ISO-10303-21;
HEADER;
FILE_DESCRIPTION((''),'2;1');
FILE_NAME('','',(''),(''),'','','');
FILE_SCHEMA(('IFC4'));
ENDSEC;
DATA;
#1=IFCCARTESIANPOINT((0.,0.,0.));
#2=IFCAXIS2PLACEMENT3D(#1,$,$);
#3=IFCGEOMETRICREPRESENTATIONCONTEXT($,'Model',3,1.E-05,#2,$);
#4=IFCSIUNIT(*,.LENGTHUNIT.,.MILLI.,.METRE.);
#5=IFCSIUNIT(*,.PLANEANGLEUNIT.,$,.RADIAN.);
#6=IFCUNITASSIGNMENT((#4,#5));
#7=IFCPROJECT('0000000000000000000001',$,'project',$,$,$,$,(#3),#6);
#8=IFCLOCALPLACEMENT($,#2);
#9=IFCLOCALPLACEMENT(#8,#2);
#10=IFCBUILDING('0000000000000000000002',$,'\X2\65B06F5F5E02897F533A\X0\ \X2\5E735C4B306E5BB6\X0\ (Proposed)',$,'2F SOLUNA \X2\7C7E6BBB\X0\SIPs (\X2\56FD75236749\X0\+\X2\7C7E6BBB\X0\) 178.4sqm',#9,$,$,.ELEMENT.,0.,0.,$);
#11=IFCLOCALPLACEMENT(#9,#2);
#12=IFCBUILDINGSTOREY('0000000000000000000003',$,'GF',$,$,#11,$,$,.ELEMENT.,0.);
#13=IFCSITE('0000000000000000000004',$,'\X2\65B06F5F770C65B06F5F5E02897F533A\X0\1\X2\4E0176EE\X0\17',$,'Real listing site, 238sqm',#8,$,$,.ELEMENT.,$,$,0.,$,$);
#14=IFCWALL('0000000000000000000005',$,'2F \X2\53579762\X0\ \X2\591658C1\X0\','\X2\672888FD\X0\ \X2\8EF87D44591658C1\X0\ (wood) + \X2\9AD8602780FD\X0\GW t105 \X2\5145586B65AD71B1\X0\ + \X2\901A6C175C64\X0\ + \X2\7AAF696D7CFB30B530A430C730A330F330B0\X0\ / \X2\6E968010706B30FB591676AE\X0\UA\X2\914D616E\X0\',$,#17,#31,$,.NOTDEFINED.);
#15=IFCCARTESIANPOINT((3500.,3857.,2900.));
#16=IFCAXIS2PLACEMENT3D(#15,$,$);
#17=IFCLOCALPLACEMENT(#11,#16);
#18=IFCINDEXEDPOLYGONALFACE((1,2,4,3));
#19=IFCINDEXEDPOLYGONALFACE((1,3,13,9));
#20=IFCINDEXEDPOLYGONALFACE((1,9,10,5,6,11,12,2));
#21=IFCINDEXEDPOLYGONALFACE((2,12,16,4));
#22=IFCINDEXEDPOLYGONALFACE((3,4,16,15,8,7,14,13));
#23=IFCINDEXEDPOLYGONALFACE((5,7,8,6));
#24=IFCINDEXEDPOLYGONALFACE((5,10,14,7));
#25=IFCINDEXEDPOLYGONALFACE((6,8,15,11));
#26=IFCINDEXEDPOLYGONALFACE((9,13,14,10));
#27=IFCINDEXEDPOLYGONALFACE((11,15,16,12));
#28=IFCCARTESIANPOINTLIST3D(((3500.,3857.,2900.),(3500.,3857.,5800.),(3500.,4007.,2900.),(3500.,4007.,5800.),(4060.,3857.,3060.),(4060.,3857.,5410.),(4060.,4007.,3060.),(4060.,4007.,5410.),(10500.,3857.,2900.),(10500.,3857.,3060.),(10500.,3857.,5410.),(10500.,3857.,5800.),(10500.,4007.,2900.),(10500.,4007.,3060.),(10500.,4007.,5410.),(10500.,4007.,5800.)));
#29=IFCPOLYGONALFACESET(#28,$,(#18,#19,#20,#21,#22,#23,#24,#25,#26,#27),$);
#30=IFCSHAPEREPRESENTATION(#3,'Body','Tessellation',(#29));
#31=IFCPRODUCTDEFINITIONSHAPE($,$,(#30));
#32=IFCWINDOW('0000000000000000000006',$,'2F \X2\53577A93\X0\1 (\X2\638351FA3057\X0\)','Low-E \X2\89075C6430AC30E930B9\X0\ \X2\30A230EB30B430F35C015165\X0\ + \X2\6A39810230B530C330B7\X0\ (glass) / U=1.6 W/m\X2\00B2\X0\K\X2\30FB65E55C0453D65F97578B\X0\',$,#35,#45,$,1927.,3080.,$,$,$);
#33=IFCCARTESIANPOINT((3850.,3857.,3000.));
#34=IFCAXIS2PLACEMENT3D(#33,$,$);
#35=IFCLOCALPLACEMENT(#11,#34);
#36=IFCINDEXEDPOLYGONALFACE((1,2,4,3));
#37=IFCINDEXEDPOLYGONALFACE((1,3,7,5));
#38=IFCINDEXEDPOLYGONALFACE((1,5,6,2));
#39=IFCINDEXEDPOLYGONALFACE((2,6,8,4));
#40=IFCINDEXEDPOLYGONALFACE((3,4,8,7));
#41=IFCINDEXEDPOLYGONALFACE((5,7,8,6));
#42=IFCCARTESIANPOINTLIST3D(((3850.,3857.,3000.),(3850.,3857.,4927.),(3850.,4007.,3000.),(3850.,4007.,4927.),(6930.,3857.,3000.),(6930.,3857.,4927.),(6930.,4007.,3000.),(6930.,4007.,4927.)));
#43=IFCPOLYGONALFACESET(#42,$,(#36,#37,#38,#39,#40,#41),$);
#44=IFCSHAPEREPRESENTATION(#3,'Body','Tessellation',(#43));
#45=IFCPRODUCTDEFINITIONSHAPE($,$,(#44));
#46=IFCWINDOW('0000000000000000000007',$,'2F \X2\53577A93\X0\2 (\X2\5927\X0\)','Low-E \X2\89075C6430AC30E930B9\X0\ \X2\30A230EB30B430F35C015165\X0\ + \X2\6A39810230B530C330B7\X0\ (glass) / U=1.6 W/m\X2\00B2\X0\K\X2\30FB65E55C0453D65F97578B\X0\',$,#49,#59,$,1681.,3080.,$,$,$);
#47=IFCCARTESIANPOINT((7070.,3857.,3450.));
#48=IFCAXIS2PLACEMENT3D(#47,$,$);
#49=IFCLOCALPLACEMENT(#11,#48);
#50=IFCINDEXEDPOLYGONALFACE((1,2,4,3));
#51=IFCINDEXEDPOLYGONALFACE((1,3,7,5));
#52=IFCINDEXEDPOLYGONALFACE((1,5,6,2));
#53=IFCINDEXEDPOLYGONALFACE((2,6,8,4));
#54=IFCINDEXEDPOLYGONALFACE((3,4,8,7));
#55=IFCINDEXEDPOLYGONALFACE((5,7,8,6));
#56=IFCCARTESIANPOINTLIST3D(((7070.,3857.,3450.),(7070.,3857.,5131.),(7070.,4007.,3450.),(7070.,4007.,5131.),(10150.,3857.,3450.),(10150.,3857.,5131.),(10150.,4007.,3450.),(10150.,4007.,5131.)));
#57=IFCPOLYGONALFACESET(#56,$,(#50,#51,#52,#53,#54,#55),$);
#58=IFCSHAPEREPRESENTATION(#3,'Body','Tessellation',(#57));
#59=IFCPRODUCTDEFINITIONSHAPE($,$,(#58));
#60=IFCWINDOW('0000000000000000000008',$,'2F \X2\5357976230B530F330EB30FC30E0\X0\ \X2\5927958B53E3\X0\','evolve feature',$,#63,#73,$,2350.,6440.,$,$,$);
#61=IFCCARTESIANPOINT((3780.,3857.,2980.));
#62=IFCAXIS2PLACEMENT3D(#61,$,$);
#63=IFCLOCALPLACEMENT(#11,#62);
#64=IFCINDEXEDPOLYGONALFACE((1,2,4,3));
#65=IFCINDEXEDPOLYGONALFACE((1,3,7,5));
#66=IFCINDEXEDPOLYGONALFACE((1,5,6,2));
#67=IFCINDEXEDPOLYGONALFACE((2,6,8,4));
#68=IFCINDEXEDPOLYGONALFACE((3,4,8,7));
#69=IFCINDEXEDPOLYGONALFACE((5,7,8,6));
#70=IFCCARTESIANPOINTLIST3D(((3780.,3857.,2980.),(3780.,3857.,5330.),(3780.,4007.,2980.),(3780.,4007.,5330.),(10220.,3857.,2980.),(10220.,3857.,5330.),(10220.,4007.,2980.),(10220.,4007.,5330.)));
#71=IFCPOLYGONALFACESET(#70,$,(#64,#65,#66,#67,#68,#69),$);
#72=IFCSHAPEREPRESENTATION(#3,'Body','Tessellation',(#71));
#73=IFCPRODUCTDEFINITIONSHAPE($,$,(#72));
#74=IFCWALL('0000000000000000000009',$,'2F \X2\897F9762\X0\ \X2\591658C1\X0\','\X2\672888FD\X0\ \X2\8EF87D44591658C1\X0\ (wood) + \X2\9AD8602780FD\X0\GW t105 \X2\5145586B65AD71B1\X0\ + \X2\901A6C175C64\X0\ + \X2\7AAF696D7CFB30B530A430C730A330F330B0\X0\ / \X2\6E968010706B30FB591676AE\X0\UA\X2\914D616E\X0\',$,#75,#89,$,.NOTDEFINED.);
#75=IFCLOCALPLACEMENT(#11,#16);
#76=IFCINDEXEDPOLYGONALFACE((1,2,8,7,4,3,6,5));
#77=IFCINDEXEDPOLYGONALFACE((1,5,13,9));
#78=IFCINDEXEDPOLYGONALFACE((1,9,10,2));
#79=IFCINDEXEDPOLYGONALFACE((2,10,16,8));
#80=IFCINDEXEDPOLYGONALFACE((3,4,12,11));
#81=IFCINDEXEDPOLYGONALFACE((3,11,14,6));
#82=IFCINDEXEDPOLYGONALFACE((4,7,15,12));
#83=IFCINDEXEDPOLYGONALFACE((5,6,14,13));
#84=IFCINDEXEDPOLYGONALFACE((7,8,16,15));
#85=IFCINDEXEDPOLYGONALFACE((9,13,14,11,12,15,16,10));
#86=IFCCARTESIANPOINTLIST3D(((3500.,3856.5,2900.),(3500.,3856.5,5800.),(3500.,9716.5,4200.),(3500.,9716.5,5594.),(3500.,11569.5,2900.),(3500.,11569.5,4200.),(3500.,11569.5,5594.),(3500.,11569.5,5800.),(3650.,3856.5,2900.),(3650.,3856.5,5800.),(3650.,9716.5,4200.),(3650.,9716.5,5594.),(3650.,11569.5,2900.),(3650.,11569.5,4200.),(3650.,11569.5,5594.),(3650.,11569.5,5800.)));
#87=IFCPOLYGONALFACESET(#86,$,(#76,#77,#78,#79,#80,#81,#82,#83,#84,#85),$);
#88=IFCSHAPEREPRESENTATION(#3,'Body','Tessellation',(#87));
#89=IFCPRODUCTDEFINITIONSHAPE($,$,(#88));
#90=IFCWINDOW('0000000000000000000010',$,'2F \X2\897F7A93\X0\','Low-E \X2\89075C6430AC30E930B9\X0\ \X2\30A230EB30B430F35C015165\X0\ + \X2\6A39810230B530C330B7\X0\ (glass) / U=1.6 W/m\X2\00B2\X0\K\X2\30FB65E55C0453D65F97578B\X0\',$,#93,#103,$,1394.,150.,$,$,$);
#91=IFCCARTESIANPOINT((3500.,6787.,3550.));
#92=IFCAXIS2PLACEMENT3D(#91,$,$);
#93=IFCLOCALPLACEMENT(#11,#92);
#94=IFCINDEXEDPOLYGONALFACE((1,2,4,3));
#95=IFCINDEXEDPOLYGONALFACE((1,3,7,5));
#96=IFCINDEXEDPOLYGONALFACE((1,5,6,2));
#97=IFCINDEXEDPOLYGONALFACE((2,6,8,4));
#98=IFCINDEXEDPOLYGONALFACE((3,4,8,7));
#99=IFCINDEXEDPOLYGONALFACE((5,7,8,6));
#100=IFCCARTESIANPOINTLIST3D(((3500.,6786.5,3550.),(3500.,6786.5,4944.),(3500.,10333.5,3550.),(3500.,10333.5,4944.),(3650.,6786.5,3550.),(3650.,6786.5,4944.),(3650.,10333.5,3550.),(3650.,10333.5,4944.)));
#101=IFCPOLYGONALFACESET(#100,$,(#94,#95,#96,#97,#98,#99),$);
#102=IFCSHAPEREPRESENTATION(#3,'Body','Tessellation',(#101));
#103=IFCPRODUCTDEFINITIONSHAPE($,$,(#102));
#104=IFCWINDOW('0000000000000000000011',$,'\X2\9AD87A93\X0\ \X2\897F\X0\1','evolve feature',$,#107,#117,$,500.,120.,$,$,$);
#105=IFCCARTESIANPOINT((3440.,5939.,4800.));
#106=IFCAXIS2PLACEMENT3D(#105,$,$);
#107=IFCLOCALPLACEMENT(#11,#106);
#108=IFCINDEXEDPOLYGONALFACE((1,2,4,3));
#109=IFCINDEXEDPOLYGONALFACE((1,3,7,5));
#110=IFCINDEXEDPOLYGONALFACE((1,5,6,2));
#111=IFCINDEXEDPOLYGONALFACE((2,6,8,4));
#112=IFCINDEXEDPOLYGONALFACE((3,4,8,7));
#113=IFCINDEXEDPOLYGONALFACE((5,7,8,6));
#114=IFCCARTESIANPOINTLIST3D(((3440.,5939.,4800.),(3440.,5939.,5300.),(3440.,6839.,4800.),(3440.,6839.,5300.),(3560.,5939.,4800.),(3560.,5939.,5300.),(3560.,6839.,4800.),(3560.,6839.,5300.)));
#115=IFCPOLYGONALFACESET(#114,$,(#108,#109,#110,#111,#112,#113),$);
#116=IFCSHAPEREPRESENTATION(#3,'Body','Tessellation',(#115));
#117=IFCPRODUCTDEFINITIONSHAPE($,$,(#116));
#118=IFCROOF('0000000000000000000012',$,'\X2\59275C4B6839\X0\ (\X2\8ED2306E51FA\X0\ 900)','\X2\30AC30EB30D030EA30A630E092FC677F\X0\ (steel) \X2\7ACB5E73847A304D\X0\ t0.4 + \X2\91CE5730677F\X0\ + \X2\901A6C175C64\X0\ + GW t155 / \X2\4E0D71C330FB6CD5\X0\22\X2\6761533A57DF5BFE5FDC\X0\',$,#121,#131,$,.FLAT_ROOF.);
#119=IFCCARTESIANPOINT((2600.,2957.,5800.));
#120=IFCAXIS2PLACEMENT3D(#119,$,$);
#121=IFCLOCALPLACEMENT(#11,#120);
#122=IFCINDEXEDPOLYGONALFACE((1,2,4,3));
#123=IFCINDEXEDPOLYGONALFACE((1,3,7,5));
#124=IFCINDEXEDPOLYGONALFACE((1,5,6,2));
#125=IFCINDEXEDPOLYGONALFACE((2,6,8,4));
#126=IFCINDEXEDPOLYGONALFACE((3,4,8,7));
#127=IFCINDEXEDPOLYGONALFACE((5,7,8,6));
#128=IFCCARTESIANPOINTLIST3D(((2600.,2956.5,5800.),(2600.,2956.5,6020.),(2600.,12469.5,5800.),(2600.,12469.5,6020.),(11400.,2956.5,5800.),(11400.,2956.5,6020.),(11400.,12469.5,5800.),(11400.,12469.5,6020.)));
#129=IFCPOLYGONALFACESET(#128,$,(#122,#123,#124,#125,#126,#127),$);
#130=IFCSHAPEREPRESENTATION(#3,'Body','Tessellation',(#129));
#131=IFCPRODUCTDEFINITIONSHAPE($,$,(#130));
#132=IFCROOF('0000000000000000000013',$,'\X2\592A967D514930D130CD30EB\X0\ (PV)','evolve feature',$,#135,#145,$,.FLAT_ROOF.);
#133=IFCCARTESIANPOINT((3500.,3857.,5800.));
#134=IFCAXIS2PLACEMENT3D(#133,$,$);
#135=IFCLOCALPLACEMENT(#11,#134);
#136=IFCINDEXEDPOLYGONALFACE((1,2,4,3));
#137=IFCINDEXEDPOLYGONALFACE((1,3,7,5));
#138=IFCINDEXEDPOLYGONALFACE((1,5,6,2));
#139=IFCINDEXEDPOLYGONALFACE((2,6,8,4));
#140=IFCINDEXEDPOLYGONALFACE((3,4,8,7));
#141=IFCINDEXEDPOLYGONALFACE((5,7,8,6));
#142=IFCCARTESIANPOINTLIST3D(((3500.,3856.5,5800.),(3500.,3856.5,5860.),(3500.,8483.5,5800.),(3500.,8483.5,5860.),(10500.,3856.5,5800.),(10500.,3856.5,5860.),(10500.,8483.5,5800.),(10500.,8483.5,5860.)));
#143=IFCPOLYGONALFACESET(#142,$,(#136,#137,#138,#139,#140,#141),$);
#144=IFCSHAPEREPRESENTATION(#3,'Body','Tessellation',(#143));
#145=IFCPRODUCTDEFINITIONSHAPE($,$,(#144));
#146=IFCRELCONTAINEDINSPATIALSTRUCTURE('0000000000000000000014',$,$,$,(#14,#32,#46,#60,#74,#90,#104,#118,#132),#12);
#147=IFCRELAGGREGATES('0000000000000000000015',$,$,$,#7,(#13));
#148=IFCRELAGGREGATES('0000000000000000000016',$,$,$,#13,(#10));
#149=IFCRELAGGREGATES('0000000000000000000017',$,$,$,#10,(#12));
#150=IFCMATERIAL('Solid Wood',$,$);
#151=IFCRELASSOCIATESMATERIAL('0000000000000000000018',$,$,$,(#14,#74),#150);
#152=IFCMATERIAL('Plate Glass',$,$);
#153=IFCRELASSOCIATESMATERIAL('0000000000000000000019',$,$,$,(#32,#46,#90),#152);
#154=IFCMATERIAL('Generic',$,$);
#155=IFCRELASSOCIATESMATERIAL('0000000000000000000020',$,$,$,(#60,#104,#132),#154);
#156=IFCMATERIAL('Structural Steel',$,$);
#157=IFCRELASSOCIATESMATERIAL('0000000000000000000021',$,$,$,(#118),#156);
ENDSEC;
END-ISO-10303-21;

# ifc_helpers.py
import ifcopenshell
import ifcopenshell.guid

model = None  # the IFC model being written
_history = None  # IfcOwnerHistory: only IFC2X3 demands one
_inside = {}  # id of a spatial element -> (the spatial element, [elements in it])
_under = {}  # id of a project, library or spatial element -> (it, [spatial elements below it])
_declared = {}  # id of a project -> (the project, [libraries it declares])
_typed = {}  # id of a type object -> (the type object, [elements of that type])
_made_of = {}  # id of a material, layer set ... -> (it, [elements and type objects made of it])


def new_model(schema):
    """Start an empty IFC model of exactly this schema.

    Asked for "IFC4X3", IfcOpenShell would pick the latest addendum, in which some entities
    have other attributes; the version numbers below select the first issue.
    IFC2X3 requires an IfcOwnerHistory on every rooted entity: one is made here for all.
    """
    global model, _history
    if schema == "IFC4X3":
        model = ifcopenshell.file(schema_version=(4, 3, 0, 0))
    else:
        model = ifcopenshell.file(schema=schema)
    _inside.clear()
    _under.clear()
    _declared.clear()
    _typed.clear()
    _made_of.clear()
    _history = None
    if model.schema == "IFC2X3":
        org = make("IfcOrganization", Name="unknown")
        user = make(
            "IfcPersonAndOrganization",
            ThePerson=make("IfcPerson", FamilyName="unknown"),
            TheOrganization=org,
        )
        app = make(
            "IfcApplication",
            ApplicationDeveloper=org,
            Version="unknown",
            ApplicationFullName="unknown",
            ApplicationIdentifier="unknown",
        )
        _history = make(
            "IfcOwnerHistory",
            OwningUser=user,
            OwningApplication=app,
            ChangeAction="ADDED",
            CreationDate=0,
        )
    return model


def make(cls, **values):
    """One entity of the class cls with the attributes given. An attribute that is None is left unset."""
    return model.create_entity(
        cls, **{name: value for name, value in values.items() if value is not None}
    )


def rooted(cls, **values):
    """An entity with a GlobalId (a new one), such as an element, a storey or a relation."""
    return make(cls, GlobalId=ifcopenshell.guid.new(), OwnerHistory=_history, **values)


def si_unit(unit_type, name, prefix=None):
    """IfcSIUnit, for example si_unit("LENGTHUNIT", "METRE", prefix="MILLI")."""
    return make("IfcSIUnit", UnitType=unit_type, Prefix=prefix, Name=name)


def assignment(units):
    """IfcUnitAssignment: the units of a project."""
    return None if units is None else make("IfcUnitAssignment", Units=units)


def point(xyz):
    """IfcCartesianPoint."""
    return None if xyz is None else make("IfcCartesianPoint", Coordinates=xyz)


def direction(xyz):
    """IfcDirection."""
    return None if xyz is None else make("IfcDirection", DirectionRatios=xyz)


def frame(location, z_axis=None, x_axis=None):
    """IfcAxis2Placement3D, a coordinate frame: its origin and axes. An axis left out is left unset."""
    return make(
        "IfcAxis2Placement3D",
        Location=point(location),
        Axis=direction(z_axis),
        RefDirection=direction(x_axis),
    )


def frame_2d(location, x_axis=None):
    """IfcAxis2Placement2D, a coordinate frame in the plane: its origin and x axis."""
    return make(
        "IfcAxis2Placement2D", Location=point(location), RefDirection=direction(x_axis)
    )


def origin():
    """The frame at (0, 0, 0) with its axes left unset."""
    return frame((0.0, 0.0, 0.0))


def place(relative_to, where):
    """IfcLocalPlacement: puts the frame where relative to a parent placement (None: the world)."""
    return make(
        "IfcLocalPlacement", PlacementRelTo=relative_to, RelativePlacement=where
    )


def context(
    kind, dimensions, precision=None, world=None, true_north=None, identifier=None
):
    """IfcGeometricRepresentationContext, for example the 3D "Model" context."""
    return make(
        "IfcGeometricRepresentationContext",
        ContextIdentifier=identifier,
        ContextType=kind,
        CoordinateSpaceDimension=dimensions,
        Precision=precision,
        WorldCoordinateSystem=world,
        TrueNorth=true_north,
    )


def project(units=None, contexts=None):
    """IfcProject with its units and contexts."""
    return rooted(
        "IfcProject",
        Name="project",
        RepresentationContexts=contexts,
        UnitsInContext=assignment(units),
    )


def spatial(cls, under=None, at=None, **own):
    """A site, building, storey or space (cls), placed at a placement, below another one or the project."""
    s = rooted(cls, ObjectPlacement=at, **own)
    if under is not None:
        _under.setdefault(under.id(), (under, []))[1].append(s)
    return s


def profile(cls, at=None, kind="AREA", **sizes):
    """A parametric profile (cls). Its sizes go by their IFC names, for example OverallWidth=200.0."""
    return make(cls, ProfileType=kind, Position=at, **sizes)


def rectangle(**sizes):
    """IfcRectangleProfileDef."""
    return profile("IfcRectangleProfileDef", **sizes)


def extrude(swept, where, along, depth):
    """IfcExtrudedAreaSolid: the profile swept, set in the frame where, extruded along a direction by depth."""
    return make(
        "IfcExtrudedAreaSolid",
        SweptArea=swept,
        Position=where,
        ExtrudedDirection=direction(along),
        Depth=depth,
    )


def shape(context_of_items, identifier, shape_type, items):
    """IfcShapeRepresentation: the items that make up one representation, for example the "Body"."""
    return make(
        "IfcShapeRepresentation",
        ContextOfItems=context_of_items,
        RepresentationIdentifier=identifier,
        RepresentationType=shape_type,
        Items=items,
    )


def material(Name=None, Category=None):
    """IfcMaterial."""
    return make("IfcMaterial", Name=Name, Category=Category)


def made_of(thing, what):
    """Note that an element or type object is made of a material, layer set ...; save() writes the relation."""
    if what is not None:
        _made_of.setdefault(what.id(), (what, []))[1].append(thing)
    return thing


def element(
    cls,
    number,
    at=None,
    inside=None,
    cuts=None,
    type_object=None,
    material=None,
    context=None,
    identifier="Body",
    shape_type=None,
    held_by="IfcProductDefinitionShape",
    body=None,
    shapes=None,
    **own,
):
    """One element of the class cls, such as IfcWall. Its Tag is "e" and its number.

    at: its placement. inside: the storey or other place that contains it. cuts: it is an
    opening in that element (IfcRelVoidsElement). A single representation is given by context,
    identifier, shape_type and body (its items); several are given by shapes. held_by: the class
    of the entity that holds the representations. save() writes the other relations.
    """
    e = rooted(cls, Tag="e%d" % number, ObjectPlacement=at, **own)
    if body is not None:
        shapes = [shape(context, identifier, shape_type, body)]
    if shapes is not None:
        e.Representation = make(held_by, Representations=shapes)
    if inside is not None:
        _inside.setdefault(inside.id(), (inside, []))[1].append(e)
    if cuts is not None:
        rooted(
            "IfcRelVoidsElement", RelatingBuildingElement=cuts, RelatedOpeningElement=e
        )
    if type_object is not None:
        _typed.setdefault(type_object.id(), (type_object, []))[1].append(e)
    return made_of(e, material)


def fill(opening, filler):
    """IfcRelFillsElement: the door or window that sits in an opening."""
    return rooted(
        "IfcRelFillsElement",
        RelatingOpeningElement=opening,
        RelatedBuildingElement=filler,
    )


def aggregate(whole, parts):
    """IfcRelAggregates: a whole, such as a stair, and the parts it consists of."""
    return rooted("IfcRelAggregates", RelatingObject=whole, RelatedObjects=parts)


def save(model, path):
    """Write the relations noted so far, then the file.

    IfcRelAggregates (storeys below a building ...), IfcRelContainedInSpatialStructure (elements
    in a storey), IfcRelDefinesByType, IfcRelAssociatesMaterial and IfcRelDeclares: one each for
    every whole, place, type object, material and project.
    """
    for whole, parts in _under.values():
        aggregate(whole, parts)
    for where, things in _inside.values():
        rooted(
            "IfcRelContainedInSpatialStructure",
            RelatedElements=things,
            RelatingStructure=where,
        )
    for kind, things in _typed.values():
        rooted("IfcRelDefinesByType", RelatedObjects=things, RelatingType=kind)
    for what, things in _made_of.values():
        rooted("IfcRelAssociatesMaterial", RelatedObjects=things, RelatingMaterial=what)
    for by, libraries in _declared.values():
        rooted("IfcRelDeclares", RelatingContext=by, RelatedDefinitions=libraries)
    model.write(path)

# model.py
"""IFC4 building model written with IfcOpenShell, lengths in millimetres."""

from ifc_helpers import new_model, si_unit, frame, frame_2d, origin, place, context, project, spatial, rectangle, extrude, material, element, fill, save


model = new_model("IFC4")

# Units and contexts
model_context = context("Model", 3, precision=1e-05, world=origin())
ifc_project = project(units=[si_unit("LENGTHUNIT", "METRE", prefix="MILLI"), si_unit("PLANEANGLEUNIT", "RADIAN")], contexts=[model_context])

# Site, building, storey
site_placement = place(None, origin())
site = spatial("IfcSite", under=ifc_project, at=site_placement, Name="新潟県新潟市西区1丁目17", ObjectType="Real listing site, 238sqm", CompositionType="ELEMENT", RefElevation=0.0)
building_placement = place(site_placement, origin())
building = spatial("IfcBuilding", under=site, at=building_placement, Name="新潟市西区 平屋の家 (Proposed)", ObjectType="2F SOLUNA 籾殻SIPs (国産杉+籾殻) 178.4sqm", CompositionType="ELEMENT", ElevationOfRefHeight=0.0, ElevationOfTerrain=0.0)
storey_placement = place(building_placement, origin())
storey = spatial("IfcBuildingStorey", under=building, at=storey_placement, Name="GF", CompositionType="ELEMENT", Elevation=0.0)

# Shared definitions
ifc_material_1 = material(Name="Solid Wood")
ifc_material_2 = material(Name="Generic")

# Shared definitions
ifc_material_3 = material(Name="Plate Glass")

# Walls, openings, windows
wall_1_placement = place(storey_placement, frame((3500.0, 3857.0, 2900.0)))
wall_1 = element("IfcWall", 1, at=wall_1_placement, inside=storey, material=ifc_material_1, Name="2F 南面 外壁", Description="木製 軸組外壁 (wood) + 高性能GW t105 充填断熱 + 通気層 + 窯業系サイディング / 準耐火・外皮UA配慮", PredefinedType="NOTDEFINED", context=model_context, shape_type="SweptSolid", body=[
    extrude(rectangle(XDim=7000.0, YDim=150.0, at=frame_2d((3500.0, 75.0))), frame((3500.0, 3857.0, 2900.0)), (0.0, 0.0, 1.0), 2900.0),
])
opening_1_placement = place(storey_placement, frame((3850.0, 3857.0, 3000.0)))
opening_1 = element("IfcOpeningElement", 2, at=opening_1_placement, cuts=wall_1, PredefinedType="NOTDEFINED", context=model_context, shape_type="SweptSolid", body=[
    extrude(rectangle(XDim=3080.0, YDim=150.0, at=frame_2d((1540.0, 75.0))), frame((3850.0, 3857.0, 3000.0)), (0.0, 0.0, 1.0), 1927.0),
])
opening_2_placement = place(storey_placement, frame((7070.0, 3857.0, 3450.0)))
opening_2 = element("IfcOpeningElement", 3, at=opening_2_placement, cuts=wall_1, PredefinedType="NOTDEFINED", context=model_context, shape_type="SweptSolid", body=[
    extrude(rectangle(XDim=3080.0, YDim=150.0, at=frame_2d((1540.0, 75.0))), frame((7070.0, 3857.0, 3450.0)), (0.0, 0.0, 1.0), 1681.0),
])
opening_3_placement = place(storey_placement, frame((3780.0, 3857.0, 2980.0)))
opening_3 = element("IfcOpeningElement", 4, at=opening_3_placement, cuts=wall_1, PredefinedType="NOTDEFINED", context=model_context, shape_type="SweptSolid", body=[
    extrude(rectangle(XDim=6440.0, YDim=150.0, at=frame_2d((3220.0, 75.0))), frame((3780.0, 3857.0, 2980.0)), (0.0, 0.0, 1.0), 2350.0),
])
window_1_placement = place(storey_placement, frame((3850.0, 3857.0, 3000.0)))
window_1 = element("IfcWindow", 5, at=window_1_placement, inside=storey, material=ifc_material_3, Name="2F 南窓1 (掃出し)", Description="Low-E 複層ガラス アルゴン封入 + 樹脂サッシ (glass) / U=1.6 W/m²K・日射取得型", OverallHeight=1927.0, OverallWidth=3080.0, context=model_context, shape_type="SweptSolid", body=[
    extrude(rectangle(XDim=3080.0, YDim=150.0, at=frame_2d((1540.0, 75.0))), frame((3850.0, 3857.0, 3000.0)), (0.0, 0.0, 1.0), 1927.0),
])
fill(opening_1, window_1)
window_2_placement = place(storey_placement, frame((7070.0, 3857.0, 3450.0)))
window_2 = element("IfcWindow", 6, at=window_2_placement, inside=storey, material=ifc_material_3, Name="2F 南窓2 (大)", Description="Low-E 複層ガラス アルゴン封入 + 樹脂サッシ (glass) / U=1.6 W/m²K・日射取得型", OverallHeight=1681.0, OverallWidth=3080.0, context=model_context, shape_type="SweptSolid", body=[
    extrude(rectangle(XDim=3080.0, YDim=150.0, at=frame_2d((1540.0, 75.0))), frame((7070.0, 3857.0, 3450.0)), (0.0, 0.0, 1.0), 1681.0),
])
fill(opening_2, window_2)
window_3_placement = place(storey_placement, frame((3780.0, 3857.0, 2980.0)))
window_3 = element("IfcWindow", 7, at=window_3_placement, inside=storey, material=ifc_material_2, Name="2F 南面サンルーム 大開口", Description="evolve feature", OverallHeight=2350.0, OverallWidth=6440.0, context=model_context, shape_type="SweptSolid", body=[
    extrude(rectangle(XDim=6440.0, YDim=150.0, at=frame_2d((3220.0, 75.0))), frame((3780.0, 3857.0, 2980.0)), (0.0, 0.0, 1.0), 2350.0),
])
fill(opening_3, window_3)
wall_2_placement = place(storey_placement, frame((3500.0, 3857.0, 2900.0)))
wall_2 = element("IfcWall", 8, at=wall_2_placement, inside=storey, material=ifc_material_1, Name="2F 西面 外壁", Description="木製 軸組外壁 (wood) + 高性能GW t105 充填断熱 + 通気層 + 窯業系サイディング / 準耐火・外皮UA配慮", PredefinedType="NOTDEFINED", context=model_context, shape_type="SweptSolid", body=[
    extrude(rectangle(XDim=150.0, YDim=7713.0, at=frame_2d((75.0, 3856.0))), frame((3500.0, 3857.0, 2900.0)), (0.0, 0.0, 1.0), 2900.0),
])
opening_4_placement = place(storey_placement, frame((3500.0, 6787.0, 3550.0)))
opening_4 = element("IfcOpeningElement", 9, at=opening_4_placement, cuts=wall_2, PredefinedType="NOTDEFINED", context=model_context, shape_type="SweptSolid", body=[
    extrude(rectangle(XDim=150.0, YDim=3547.0, at=frame_2d((75.0, 1773.0))), frame((3500.0, 6787.0, 3550.0)), (0.0, 0.0, 1.0), 1394.0),
])
opening_5_placement = place(storey_placement, frame((3440.0, 5939.0, 4800.0)))
opening_5 = element("IfcOpeningElement", 10, at=opening_5_placement, cuts=wall_2, PredefinedType="NOTDEFINED", context=model_context, shape_type="SweptSolid", body=[
    extrude(rectangle(XDim=120.0, YDim=900.0, at=frame_2d((60.0, 450.0))), frame((3440.0, 5939.0, 4800.0)), (0.0, 0.0, 1.0), 500.0),
])
window_4_placement = place(storey_placement, frame((3500.0, 6787.0, 3550.0)))
window_4 = element("IfcWindow", 11, at=window_4_placement, inside=storey, material=ifc_material_3, Name="2F 西窓", Description="Low-E 複層ガラス アルゴン封入 + 樹脂サッシ (glass) / U=1.6 W/m²K・日射取得型", OverallHeight=1394.0, OverallWidth=150.0, context=model_context, shape_type="SweptSolid", body=[
    extrude(rectangle(XDim=150.0, YDim=3547.0, at=frame_2d((75.0, 1773.0))), frame((3500.0, 6787.0, 3550.0)), (0.0, 0.0, 1.0), 1394.0),
])
fill(opening_4, window_4)
window_5_placement = place(storey_placement, frame((3440.0, 5939.0, 4800.0)))
window_5 = element("IfcWindow", 12, at=window_5_placement, inside=storey, material=ifc_material_2, Name="高窓 西1", Description="evolve feature", OverallHeight=500.0, OverallWidth=120.0, context=model_context, shape_type="SweptSolid", body=[
    extrude(rectangle(XDim=120.0, YDim=900.0, at=frame_2d((60.0, 450.0))), frame((3440.0, 5939.0, 4800.0)), (0.0, 0.0, 1.0), 500.0),
])
fill(opening_5, window_5)

# Roofs
ifc_material_4 = material(Name="Structural Steel")
roof_1_placement = place(storey_placement, frame((2600.0, 2957.0, 5800.0)))
element("IfcRoof", 13, at=roof_1_placement, inside=storey, material=ifc_material_4, Name="大屋根 (軒の出 900)", Description="ガルバリウム鋼板 (steel) 立平葺き t0.4 + 野地板 + 通気層 + GW t155 / 不燃・法22条区域対応", PredefinedType="FLAT_ROOF", context=model_context, shape_type="SweptSolid", body=[
    extrude(rectangle(XDim=8800.0, YDim=9513.0, at=frame_2d((4400.0, 4756.0))), frame((2600.0, 2957.0, 5800.0)), (0.0, 0.0, 1.0), 220.0),
])
roof_2_placement = place(storey_placement, frame((3500.0, 3857.0, 5800.0)))
element("IfcRoof", 14, at=roof_2_placement, inside=storey, material=ifc_material_2, Name="太陽光パネル (PV)", Description="evolve feature", PredefinedType="FLAT_ROOF", context=model_context, shape_type="SweptSolid", body=[
    extrude(rectangle(XDim=7000.0, YDim=4627.0, at=frame_2d((3500.0, 2313.0))), frame((3500.0, 3857.0, 5800.0)), (0.0, 0.0, 1.0), 60.0),
])

save(model, "model.ifc")
